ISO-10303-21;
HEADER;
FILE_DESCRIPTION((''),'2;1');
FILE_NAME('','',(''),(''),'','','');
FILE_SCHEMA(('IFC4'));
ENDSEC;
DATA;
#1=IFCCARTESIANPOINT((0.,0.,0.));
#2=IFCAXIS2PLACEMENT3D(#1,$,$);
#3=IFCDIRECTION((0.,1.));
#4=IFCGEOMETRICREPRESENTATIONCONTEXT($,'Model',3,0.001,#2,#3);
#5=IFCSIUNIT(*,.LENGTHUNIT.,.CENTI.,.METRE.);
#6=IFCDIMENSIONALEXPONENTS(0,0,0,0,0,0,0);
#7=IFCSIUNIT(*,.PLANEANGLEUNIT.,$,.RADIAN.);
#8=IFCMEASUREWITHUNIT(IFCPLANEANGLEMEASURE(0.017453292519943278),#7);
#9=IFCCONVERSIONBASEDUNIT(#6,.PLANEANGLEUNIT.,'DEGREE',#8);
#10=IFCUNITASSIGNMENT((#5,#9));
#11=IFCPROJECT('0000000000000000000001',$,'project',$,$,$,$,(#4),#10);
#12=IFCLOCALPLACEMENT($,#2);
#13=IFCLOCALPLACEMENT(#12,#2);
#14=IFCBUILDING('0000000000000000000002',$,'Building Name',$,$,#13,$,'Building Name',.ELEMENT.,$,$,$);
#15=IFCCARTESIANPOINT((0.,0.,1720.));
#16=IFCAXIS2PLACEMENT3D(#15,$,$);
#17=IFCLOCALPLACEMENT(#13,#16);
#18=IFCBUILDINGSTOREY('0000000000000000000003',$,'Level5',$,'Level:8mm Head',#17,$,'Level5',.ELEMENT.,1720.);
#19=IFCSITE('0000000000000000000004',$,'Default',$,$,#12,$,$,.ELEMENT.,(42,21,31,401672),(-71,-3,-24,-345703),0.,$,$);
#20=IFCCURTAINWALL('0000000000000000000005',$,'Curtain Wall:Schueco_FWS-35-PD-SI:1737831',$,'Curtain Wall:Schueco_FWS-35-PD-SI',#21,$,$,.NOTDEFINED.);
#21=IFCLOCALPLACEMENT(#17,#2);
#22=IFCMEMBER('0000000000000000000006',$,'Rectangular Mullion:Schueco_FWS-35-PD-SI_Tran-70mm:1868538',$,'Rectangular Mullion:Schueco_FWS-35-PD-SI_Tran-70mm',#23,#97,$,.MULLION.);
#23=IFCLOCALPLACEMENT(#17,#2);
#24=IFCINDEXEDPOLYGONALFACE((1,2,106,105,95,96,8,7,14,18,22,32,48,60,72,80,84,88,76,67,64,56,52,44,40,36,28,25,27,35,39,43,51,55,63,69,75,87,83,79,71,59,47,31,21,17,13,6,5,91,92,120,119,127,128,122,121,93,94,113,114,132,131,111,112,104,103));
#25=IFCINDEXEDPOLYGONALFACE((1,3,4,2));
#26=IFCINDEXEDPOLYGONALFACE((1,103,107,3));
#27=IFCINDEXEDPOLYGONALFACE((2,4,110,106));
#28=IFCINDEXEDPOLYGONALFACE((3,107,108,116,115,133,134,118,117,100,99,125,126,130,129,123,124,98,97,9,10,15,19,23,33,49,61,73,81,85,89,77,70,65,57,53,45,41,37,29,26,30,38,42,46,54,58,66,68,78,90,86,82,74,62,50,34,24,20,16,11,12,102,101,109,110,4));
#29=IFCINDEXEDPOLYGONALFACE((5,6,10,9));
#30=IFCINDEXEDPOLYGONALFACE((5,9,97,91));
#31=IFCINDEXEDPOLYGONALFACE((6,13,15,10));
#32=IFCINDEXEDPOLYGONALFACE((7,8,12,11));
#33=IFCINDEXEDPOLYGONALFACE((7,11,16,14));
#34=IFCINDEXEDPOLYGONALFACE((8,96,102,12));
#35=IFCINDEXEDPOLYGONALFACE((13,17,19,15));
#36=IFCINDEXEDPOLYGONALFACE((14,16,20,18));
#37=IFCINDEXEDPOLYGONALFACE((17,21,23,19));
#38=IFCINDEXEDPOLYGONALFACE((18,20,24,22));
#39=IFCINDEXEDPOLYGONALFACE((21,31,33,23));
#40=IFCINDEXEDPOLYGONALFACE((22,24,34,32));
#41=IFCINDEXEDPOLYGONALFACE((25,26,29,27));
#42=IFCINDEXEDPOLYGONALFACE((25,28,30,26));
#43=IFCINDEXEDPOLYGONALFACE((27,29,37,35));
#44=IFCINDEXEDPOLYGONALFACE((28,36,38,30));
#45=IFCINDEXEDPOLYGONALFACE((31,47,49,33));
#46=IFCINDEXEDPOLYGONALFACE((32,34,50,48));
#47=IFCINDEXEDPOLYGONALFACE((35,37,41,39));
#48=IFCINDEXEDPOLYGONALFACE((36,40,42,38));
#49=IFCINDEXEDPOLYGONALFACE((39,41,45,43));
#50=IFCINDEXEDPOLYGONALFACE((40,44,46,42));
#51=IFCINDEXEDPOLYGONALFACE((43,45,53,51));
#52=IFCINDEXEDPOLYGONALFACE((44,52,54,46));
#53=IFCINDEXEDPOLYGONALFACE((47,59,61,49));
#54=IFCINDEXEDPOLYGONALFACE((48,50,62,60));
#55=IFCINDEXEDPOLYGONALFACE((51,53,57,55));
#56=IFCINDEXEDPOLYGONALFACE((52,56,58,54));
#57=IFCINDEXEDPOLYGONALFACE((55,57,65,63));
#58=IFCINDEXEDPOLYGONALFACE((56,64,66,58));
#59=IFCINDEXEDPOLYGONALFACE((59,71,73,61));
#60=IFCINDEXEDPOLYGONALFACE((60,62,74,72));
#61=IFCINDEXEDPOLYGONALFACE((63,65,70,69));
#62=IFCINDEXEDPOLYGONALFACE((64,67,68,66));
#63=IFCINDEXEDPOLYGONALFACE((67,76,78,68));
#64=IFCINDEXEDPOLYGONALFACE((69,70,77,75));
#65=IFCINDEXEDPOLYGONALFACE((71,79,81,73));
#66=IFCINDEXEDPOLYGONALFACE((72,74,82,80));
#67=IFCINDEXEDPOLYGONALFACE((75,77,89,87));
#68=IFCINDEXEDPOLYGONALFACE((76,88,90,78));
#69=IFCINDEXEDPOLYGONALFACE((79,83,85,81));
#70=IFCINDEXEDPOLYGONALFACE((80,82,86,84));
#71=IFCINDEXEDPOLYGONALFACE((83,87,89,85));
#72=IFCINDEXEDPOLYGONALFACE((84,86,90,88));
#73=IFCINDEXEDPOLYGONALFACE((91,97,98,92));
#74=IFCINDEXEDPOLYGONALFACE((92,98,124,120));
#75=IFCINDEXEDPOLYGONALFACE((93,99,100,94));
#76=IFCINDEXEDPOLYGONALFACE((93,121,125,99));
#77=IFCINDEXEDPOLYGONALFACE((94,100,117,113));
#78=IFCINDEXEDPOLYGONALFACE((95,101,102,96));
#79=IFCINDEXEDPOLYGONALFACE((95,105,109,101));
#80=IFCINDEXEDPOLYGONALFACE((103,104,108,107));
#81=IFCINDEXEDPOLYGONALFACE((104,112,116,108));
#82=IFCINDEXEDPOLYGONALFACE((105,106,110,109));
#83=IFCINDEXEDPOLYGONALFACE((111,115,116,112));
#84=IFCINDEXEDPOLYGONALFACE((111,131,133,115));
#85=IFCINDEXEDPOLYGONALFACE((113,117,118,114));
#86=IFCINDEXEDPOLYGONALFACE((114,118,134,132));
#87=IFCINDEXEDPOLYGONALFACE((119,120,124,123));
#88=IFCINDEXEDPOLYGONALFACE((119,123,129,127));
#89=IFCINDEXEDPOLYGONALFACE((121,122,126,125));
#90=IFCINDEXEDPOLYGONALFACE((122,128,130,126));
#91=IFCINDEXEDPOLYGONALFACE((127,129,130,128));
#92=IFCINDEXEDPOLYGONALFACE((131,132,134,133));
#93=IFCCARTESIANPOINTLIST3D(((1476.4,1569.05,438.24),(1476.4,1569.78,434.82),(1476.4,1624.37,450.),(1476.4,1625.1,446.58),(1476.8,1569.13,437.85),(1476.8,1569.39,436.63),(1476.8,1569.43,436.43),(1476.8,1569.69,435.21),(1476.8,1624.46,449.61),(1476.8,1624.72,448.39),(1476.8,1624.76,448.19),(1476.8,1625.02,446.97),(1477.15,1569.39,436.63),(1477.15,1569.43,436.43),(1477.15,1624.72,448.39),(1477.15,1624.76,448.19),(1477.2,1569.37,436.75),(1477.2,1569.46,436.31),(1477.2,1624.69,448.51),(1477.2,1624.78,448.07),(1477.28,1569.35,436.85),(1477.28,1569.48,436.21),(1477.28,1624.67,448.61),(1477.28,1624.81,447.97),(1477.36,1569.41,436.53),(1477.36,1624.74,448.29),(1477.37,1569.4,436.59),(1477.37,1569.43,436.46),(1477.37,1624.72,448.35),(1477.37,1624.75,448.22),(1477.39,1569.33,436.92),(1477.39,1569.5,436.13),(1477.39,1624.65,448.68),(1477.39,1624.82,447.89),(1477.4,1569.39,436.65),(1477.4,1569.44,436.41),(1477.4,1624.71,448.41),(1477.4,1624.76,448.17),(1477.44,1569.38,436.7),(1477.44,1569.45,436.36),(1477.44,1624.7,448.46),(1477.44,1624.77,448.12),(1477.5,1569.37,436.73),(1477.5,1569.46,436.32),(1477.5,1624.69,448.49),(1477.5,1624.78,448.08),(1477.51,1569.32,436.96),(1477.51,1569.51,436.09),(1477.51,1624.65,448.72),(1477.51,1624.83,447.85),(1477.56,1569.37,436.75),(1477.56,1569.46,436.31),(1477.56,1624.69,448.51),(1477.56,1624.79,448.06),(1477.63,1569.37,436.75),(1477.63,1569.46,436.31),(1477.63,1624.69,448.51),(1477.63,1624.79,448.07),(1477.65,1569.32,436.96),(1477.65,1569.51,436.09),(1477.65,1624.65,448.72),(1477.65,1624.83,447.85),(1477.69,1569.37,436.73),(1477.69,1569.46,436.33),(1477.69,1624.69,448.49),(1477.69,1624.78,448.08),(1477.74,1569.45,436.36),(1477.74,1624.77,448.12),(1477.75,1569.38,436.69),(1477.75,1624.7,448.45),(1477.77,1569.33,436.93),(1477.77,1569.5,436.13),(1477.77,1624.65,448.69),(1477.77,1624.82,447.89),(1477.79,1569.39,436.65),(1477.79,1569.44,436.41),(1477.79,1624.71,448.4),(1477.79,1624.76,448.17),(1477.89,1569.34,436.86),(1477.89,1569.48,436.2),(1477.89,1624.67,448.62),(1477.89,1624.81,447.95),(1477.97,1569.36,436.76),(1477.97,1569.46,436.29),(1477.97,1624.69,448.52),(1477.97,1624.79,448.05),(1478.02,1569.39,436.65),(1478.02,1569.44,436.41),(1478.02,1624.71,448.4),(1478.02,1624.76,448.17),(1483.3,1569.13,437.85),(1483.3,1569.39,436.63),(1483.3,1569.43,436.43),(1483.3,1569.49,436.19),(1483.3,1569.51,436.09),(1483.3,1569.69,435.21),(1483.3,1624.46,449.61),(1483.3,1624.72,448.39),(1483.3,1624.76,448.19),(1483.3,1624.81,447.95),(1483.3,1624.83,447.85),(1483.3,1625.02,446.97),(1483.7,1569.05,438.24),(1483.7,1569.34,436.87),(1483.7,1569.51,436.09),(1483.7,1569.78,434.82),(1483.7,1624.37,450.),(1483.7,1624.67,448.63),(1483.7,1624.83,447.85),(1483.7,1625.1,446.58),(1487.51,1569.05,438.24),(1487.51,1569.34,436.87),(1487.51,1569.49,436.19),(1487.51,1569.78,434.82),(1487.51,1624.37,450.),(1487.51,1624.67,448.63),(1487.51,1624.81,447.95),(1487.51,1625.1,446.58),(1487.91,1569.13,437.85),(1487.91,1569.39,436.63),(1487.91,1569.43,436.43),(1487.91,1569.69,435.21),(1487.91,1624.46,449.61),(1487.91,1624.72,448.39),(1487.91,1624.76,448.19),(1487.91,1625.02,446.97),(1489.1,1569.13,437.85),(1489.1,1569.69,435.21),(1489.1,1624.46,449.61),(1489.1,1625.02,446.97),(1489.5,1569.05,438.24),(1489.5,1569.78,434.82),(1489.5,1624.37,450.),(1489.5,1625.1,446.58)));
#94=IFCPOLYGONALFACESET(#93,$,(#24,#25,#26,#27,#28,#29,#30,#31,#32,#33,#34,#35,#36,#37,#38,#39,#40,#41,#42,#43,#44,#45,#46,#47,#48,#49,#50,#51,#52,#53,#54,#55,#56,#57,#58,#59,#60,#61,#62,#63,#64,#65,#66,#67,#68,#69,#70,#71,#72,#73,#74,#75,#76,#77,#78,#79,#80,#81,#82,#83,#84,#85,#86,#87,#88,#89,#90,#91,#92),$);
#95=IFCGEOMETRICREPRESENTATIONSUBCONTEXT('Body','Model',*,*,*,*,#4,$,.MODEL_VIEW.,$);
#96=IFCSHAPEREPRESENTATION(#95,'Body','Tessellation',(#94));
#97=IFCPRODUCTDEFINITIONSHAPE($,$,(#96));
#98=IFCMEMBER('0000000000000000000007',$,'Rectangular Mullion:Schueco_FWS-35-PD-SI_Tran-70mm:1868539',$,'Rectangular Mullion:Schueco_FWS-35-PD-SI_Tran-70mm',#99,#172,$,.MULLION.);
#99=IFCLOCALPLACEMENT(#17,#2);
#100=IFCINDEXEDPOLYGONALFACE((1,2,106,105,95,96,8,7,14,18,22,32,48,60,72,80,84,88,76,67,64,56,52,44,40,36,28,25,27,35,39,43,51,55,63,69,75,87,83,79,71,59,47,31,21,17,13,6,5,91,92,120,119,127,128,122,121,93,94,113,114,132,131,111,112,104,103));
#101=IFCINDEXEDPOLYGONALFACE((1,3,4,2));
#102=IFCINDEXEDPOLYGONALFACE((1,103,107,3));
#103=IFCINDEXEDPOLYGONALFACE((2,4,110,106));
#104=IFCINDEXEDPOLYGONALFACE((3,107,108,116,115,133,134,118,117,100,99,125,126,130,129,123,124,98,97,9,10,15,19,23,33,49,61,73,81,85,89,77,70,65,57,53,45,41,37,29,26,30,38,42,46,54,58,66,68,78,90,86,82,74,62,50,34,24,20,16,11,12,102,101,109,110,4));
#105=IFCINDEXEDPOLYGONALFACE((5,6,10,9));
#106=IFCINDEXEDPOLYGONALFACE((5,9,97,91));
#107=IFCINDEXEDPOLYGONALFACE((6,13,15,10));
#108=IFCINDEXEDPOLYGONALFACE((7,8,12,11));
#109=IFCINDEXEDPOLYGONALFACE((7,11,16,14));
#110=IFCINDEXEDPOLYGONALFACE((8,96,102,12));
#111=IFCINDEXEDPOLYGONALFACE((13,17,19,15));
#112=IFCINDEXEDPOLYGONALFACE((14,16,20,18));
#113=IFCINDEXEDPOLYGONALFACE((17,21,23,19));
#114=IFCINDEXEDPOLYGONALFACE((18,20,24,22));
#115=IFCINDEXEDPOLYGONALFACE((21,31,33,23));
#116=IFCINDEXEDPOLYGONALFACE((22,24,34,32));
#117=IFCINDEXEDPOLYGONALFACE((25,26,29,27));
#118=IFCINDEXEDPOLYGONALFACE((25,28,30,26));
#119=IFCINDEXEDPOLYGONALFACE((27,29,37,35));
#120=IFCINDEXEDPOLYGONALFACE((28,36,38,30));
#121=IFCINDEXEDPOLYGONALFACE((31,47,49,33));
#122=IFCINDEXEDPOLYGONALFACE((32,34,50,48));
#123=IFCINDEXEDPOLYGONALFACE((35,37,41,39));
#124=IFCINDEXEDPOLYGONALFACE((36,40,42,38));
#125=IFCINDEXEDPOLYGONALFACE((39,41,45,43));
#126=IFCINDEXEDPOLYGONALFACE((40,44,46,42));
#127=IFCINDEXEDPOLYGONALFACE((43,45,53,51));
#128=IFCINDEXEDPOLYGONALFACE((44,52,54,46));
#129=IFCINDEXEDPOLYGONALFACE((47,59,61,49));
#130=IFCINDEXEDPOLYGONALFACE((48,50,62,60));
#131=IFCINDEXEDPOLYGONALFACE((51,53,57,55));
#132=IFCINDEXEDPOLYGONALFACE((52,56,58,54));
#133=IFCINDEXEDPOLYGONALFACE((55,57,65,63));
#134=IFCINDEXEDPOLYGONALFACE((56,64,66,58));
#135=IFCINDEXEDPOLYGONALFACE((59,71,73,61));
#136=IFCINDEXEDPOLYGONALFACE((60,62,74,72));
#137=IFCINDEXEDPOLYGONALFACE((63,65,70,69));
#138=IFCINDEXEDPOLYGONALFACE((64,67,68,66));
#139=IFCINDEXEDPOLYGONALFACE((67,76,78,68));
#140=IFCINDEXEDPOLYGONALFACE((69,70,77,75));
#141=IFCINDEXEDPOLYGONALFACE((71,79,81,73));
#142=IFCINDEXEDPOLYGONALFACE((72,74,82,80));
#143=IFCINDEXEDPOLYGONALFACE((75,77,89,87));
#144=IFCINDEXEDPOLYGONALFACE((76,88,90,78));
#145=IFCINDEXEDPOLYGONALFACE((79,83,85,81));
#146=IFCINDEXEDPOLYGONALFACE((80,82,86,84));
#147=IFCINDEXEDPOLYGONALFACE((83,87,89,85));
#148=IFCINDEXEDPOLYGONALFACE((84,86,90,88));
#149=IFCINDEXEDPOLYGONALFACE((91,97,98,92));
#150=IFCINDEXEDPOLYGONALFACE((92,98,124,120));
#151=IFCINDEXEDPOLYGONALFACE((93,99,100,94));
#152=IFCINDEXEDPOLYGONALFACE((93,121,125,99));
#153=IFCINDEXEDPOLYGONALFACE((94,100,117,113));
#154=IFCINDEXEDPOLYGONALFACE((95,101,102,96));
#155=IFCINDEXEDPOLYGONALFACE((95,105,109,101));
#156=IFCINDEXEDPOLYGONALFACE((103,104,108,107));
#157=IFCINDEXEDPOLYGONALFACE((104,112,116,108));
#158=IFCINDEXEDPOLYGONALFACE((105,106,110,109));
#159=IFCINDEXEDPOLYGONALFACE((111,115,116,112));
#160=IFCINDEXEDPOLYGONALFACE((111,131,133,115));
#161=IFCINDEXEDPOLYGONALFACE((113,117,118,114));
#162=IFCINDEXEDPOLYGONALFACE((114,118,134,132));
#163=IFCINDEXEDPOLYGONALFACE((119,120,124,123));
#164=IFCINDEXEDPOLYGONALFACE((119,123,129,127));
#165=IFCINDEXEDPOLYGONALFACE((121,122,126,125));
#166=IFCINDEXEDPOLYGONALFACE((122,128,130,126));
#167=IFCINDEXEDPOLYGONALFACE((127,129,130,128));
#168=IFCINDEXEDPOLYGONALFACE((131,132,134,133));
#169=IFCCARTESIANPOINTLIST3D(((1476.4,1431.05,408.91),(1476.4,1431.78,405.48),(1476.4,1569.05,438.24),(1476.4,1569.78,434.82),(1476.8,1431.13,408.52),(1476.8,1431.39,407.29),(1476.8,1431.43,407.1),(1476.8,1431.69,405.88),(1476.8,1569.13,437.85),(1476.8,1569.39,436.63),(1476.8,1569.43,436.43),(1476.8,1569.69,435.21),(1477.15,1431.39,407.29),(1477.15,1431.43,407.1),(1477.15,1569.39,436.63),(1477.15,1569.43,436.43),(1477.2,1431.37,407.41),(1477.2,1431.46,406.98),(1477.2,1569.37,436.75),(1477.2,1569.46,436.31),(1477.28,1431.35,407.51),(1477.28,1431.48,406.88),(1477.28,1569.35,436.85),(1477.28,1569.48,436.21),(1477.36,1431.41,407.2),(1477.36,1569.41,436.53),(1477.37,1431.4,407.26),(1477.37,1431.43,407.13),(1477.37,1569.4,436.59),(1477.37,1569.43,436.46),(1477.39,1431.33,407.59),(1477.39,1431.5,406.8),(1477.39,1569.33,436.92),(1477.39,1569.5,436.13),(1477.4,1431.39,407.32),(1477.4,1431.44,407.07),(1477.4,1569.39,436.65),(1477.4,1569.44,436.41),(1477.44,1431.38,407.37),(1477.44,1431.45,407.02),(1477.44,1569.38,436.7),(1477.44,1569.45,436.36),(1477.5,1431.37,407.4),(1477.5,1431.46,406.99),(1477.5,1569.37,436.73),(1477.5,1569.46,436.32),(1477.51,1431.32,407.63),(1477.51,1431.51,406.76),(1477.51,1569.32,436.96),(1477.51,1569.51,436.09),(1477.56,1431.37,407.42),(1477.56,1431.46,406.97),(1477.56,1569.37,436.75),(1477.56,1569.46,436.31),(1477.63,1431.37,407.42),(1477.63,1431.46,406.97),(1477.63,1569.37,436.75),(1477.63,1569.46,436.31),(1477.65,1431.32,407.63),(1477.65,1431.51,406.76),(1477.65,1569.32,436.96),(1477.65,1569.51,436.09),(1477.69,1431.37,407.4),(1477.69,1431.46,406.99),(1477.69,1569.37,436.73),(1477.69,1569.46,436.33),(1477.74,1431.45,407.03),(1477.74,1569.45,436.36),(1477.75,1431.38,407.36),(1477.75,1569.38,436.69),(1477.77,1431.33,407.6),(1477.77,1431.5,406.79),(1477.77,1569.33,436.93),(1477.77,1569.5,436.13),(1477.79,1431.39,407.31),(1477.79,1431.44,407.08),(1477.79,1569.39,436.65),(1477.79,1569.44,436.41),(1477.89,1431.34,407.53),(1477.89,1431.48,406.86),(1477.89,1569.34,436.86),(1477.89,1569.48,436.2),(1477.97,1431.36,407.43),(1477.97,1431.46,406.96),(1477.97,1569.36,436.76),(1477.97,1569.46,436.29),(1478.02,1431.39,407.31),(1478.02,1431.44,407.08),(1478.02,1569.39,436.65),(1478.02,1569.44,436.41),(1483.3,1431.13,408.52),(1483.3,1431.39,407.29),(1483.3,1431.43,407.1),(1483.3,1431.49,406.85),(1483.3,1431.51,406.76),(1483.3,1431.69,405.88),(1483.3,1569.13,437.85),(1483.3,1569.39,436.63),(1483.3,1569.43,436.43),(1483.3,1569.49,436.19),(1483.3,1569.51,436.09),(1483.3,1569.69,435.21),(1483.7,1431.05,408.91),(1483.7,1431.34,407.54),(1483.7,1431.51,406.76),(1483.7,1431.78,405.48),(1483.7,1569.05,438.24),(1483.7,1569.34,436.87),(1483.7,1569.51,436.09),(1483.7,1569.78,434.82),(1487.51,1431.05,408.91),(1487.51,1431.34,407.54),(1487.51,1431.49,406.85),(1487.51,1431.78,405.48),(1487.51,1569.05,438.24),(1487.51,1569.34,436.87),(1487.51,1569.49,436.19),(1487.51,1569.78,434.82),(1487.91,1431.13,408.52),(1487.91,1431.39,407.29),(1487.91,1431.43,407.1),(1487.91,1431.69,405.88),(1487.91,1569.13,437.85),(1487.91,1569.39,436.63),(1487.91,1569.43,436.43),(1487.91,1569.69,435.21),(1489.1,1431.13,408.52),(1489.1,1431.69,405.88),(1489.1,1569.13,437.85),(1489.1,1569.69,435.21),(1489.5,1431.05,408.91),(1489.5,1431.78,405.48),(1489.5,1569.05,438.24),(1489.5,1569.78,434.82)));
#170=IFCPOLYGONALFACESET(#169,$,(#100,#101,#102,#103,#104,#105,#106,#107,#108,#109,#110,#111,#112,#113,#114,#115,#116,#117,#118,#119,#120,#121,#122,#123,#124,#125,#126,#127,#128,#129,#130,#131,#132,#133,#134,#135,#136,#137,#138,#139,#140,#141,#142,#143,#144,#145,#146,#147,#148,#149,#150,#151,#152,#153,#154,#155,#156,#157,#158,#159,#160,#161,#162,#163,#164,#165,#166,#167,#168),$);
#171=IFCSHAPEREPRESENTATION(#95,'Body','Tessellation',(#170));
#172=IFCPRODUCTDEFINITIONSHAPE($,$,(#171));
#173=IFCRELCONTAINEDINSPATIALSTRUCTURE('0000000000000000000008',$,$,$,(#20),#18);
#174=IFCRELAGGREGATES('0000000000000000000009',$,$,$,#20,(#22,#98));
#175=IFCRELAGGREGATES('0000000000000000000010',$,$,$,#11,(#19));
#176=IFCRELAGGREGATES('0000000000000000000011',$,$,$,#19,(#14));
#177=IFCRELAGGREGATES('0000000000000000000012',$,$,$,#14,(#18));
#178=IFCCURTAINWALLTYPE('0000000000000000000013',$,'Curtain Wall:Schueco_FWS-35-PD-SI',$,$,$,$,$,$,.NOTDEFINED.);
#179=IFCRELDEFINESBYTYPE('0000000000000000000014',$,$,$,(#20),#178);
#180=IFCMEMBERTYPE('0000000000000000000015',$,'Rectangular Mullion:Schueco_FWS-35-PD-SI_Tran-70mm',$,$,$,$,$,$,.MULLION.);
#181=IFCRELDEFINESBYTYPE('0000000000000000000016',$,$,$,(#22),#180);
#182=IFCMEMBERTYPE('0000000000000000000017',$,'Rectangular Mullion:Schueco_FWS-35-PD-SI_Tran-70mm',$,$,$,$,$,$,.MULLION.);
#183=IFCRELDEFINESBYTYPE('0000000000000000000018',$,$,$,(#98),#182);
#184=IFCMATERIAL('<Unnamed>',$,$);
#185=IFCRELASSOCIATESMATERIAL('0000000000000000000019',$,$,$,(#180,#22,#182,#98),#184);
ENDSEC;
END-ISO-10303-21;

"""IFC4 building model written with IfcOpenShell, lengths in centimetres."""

from ifc_helpers import new_model, entity, si_unit, converted_unit, direction, frame, origin, place, context, subcontext, project, spatial, line, arc, indexed_curve, outline, extrude, source, transform, mapped, material, type_object, type_shapes, element, aggregate, save


model = new_model("IFC4")

# Units and contexts
model_context = context("Model", 3, precision=0.001, world=origin(), true_north=direction((0.0, 1.0)))
body_context = subcontext(model_context, "Body", "Model", "MODEL_VIEW")
ifc_project = project(units=[si_unit("LENGTHUNIT", "METRE", prefix="CENTI"), converted_unit("PLANEANGLEUNIT", "DEGREE", entity("IfcPlaneAngleMeasure", 0.017453292519943278), si_unit("PLANEANGLEUNIT", "RADIAN"), dimensions=[0, 0, 0, 0, 0, 0, 0])], contexts=[model_context])

# Site, building, storey
site_placement = place(None, origin())
site = spatial("IfcSite", under=ifc_project, at=site_placement, Name="Default", CompositionType="ELEMENT", RefLatitude=(42, 21, 31, 401672), RefLongitude=(-71, -3, -24, -345703), RefElevation=0.0)
building_placement = place(site_placement, origin())
building = spatial("IfcBuilding", under=site, at=building_placement, Name="Building Name", LongName="Building Name", CompositionType="ELEMENT")
storey_placement = place(building_placement, frame((0.0, 0.0, 1720.0)))
storey = spatial("IfcBuildingStorey", under=building, at=storey_placement, Name="Level5", ObjectType="Level:8mm Head", LongName="Level5", CompositionType="ELEMENT", Elevation=1720.0)

# Curtain wall, members
curtain_wall_type = type_object("IfcCurtainWallType", Name="Curtain Wall:Schueco_FWS-35-PD-SI", PredefinedType="NOTDEFINED")
curtain_wall_placement = place(storey_placement, frame((0.0, 0.0, -1720.0)))
curtain_wall = element("IfcCurtainWall", 1, at=curtain_wall_placement, inside=storey, type_object=curtain_wall_type, Name="Curtain Wall:Schueco_FWS-35-PD-SI:1737831", ObjectType="Curtain Wall:Schueco_FWS-35-PD-SI", PredefinedType="NOTDEFINED")
ifc_material_1 = material(Name="<Unnamed>")
member_type_1 = type_object("IfcMemberType", Name="Rectangular Mullion:Schueco_FWS-35-PD-SI_Tran-70mm", PredefinedType="MULLION", material=ifc_material_1)
shared_shape_1 = source(origin(), body_context, "Body", "SweptSolid", [
    extrude(outline(indexed_curve([(-1.78, -6.52), (1.72, -6.52), (1.72, 0.78), (0.42, 0.78), (0.42, 0.38), (1.32, 0.38), (1.32, -6.12), (0.07, -6.12), (0.07, -5.77), (0.42, -5.34), (0.09, -4.9), (0.09, -5.14), (-0.03, -5.56), (-0.15, -5.14), (-0.15, -4.9), (-0.48, -5.34), (-0.13, -5.77), (-0.13, -6.12), (-1.38, -6.12), (-1.38, 0.38), (-0.13, 0.38), (-0.13, 4.99), (-1.38, 4.99), (-1.38, 6.18), (1.32, 6.18), (1.32, 4.99), (0.07, 4.99), (0.07, 0.38), (0.32, 0.38), (0.32, 4.59), (1.72, 4.59), (1.72, 6.58), (-1.78, 6.58), (-1.78, 4.59), (-0.38, 4.59), (-0.38, 0.78), (-1.78, 0.78)], segments=[line(1, 2, 3, 4, 5, 6, 7, 8, 9), arc(9, 10, 11), line(11, 12), arc(12, 13, 14), line(14, 15), arc(15, 16, 17), line(17, 18, 19, 20, 21, 22, 23, 24, 25, 26, 27, 28, 29, 30, 31, 32, 33, 34, 35, 36, 37, 1)], self_intersect=False)), frame((-1.78, 4.58, -56.56), z_axis=(0.0, 0.0, 1.0), x_axis=(-1.0, 0.0, 0.0)), (0.0, 0.0, 1.0), 56.56),
])
type_shapes(member_type_1, [shared_shape_1])
member_1_placement = place(curtain_wall_placement, frame((1487.5, 1569.05, 2158.24), z_axis=(0.0, -0.978148, -0.207912), x_axis=(0.0, -0.207912, 0.978148)))
member_1 = element("IfcMember", 2, at=member_1_placement, type_object=member_type_1, material=ifc_material_1, Name="Rectangular Mullion:Schueco_FWS-35-PD-SI_Tran-70mm:1868538", ObjectType="Rectangular Mullion:Schueco_FWS-35-PD-SI_Tran-70mm", PredefinedType="MULLION", context=body_context, shape_type="MappedRepresentation", body=[
    mapped(shared_shape_1, transform((0.0, 0.0, 0.0), scale=1.0)),
])
member_type_2 = type_object("IfcMemberType", Name="Rectangular Mullion:Schueco_FWS-35-PD-SI_Tran-70mm", PredefinedType="MULLION", material=ifc_material_1)
shared_shape_2 = source(origin(), body_context, "Body", "SweptSolid", [
    extrude(outline(indexed_curve([(-1.78, -6.52), (1.72, -6.52), (1.72, 0.78), (0.42, 0.78), (0.42, 0.38), (1.32, 0.38), (1.32, -6.12), (0.07, -6.12), (0.07, -5.77), (0.42, -5.34), (0.09, -4.9), (0.09, -5.14), (-0.03, -5.56), (-0.15, -5.14), (-0.15, -4.9), (-0.48, -5.34), (-0.13, -5.77), (-0.13, -6.12), (-1.38, -6.12), (-1.38, 0.38), (-0.13, 0.38), (-0.13, 4.99), (-1.38, 4.99), (-1.38, 6.18), (1.32, 6.18), (1.32, 4.99), (0.07, 4.99), (0.07, 0.38), (0.32, 0.38), (0.32, 4.59), (1.72, 4.59), (1.72, 6.58), (-1.78, 6.58), (-1.78, 4.59), (-0.38, 4.59), (-0.38, 0.78), (-1.78, 0.78)], segments=[line(1, 2, 3, 4, 5, 6, 7, 8, 9), arc(9, 10, 11), line(11, 12), arc(12, 13, 14), line(14, 15), arc(15, 16, 17), line(17, 18, 19, 20, 21, 22, 23, 24, 25, 26, 27, 28, 29, 30, 31, 32, 33, 34, 35, 36, 37, 1)], self_intersect=False)), frame((-1.78, 4.58, -141.08), z_axis=(0.0, 0.0, 1.0), x_axis=(-1.0, 0.0, 0.0)), (0.0, 0.0, 1.0), 141.08),
])
type_shapes(member_type_2, [shared_shape_2])
member_2_placement = place(curtain_wall_placement, frame((1487.5, 1431.05, 2128.91), z_axis=(0.0, -0.978148, -0.207912), x_axis=(0.0, -0.207912, 0.978148)))
member_2 = element("IfcMember", 3, at=member_2_placement, type_object=member_type_2, material=ifc_material_1, Name="Rectangular Mullion:Schueco_FWS-35-PD-SI_Tran-70mm:1868539", ObjectType="Rectangular Mullion:Schueco_FWS-35-PD-SI_Tran-70mm", PredefinedType="MULLION", context=body_context, shape_type="MappedRepresentation", body=[
    mapped(shared_shape_2, transform((0.0, 0.0, 0.0), scale=1.0)),
])
aggregate(curtain_wall, [member_1, member_2])

save(model, "model.ifc")
